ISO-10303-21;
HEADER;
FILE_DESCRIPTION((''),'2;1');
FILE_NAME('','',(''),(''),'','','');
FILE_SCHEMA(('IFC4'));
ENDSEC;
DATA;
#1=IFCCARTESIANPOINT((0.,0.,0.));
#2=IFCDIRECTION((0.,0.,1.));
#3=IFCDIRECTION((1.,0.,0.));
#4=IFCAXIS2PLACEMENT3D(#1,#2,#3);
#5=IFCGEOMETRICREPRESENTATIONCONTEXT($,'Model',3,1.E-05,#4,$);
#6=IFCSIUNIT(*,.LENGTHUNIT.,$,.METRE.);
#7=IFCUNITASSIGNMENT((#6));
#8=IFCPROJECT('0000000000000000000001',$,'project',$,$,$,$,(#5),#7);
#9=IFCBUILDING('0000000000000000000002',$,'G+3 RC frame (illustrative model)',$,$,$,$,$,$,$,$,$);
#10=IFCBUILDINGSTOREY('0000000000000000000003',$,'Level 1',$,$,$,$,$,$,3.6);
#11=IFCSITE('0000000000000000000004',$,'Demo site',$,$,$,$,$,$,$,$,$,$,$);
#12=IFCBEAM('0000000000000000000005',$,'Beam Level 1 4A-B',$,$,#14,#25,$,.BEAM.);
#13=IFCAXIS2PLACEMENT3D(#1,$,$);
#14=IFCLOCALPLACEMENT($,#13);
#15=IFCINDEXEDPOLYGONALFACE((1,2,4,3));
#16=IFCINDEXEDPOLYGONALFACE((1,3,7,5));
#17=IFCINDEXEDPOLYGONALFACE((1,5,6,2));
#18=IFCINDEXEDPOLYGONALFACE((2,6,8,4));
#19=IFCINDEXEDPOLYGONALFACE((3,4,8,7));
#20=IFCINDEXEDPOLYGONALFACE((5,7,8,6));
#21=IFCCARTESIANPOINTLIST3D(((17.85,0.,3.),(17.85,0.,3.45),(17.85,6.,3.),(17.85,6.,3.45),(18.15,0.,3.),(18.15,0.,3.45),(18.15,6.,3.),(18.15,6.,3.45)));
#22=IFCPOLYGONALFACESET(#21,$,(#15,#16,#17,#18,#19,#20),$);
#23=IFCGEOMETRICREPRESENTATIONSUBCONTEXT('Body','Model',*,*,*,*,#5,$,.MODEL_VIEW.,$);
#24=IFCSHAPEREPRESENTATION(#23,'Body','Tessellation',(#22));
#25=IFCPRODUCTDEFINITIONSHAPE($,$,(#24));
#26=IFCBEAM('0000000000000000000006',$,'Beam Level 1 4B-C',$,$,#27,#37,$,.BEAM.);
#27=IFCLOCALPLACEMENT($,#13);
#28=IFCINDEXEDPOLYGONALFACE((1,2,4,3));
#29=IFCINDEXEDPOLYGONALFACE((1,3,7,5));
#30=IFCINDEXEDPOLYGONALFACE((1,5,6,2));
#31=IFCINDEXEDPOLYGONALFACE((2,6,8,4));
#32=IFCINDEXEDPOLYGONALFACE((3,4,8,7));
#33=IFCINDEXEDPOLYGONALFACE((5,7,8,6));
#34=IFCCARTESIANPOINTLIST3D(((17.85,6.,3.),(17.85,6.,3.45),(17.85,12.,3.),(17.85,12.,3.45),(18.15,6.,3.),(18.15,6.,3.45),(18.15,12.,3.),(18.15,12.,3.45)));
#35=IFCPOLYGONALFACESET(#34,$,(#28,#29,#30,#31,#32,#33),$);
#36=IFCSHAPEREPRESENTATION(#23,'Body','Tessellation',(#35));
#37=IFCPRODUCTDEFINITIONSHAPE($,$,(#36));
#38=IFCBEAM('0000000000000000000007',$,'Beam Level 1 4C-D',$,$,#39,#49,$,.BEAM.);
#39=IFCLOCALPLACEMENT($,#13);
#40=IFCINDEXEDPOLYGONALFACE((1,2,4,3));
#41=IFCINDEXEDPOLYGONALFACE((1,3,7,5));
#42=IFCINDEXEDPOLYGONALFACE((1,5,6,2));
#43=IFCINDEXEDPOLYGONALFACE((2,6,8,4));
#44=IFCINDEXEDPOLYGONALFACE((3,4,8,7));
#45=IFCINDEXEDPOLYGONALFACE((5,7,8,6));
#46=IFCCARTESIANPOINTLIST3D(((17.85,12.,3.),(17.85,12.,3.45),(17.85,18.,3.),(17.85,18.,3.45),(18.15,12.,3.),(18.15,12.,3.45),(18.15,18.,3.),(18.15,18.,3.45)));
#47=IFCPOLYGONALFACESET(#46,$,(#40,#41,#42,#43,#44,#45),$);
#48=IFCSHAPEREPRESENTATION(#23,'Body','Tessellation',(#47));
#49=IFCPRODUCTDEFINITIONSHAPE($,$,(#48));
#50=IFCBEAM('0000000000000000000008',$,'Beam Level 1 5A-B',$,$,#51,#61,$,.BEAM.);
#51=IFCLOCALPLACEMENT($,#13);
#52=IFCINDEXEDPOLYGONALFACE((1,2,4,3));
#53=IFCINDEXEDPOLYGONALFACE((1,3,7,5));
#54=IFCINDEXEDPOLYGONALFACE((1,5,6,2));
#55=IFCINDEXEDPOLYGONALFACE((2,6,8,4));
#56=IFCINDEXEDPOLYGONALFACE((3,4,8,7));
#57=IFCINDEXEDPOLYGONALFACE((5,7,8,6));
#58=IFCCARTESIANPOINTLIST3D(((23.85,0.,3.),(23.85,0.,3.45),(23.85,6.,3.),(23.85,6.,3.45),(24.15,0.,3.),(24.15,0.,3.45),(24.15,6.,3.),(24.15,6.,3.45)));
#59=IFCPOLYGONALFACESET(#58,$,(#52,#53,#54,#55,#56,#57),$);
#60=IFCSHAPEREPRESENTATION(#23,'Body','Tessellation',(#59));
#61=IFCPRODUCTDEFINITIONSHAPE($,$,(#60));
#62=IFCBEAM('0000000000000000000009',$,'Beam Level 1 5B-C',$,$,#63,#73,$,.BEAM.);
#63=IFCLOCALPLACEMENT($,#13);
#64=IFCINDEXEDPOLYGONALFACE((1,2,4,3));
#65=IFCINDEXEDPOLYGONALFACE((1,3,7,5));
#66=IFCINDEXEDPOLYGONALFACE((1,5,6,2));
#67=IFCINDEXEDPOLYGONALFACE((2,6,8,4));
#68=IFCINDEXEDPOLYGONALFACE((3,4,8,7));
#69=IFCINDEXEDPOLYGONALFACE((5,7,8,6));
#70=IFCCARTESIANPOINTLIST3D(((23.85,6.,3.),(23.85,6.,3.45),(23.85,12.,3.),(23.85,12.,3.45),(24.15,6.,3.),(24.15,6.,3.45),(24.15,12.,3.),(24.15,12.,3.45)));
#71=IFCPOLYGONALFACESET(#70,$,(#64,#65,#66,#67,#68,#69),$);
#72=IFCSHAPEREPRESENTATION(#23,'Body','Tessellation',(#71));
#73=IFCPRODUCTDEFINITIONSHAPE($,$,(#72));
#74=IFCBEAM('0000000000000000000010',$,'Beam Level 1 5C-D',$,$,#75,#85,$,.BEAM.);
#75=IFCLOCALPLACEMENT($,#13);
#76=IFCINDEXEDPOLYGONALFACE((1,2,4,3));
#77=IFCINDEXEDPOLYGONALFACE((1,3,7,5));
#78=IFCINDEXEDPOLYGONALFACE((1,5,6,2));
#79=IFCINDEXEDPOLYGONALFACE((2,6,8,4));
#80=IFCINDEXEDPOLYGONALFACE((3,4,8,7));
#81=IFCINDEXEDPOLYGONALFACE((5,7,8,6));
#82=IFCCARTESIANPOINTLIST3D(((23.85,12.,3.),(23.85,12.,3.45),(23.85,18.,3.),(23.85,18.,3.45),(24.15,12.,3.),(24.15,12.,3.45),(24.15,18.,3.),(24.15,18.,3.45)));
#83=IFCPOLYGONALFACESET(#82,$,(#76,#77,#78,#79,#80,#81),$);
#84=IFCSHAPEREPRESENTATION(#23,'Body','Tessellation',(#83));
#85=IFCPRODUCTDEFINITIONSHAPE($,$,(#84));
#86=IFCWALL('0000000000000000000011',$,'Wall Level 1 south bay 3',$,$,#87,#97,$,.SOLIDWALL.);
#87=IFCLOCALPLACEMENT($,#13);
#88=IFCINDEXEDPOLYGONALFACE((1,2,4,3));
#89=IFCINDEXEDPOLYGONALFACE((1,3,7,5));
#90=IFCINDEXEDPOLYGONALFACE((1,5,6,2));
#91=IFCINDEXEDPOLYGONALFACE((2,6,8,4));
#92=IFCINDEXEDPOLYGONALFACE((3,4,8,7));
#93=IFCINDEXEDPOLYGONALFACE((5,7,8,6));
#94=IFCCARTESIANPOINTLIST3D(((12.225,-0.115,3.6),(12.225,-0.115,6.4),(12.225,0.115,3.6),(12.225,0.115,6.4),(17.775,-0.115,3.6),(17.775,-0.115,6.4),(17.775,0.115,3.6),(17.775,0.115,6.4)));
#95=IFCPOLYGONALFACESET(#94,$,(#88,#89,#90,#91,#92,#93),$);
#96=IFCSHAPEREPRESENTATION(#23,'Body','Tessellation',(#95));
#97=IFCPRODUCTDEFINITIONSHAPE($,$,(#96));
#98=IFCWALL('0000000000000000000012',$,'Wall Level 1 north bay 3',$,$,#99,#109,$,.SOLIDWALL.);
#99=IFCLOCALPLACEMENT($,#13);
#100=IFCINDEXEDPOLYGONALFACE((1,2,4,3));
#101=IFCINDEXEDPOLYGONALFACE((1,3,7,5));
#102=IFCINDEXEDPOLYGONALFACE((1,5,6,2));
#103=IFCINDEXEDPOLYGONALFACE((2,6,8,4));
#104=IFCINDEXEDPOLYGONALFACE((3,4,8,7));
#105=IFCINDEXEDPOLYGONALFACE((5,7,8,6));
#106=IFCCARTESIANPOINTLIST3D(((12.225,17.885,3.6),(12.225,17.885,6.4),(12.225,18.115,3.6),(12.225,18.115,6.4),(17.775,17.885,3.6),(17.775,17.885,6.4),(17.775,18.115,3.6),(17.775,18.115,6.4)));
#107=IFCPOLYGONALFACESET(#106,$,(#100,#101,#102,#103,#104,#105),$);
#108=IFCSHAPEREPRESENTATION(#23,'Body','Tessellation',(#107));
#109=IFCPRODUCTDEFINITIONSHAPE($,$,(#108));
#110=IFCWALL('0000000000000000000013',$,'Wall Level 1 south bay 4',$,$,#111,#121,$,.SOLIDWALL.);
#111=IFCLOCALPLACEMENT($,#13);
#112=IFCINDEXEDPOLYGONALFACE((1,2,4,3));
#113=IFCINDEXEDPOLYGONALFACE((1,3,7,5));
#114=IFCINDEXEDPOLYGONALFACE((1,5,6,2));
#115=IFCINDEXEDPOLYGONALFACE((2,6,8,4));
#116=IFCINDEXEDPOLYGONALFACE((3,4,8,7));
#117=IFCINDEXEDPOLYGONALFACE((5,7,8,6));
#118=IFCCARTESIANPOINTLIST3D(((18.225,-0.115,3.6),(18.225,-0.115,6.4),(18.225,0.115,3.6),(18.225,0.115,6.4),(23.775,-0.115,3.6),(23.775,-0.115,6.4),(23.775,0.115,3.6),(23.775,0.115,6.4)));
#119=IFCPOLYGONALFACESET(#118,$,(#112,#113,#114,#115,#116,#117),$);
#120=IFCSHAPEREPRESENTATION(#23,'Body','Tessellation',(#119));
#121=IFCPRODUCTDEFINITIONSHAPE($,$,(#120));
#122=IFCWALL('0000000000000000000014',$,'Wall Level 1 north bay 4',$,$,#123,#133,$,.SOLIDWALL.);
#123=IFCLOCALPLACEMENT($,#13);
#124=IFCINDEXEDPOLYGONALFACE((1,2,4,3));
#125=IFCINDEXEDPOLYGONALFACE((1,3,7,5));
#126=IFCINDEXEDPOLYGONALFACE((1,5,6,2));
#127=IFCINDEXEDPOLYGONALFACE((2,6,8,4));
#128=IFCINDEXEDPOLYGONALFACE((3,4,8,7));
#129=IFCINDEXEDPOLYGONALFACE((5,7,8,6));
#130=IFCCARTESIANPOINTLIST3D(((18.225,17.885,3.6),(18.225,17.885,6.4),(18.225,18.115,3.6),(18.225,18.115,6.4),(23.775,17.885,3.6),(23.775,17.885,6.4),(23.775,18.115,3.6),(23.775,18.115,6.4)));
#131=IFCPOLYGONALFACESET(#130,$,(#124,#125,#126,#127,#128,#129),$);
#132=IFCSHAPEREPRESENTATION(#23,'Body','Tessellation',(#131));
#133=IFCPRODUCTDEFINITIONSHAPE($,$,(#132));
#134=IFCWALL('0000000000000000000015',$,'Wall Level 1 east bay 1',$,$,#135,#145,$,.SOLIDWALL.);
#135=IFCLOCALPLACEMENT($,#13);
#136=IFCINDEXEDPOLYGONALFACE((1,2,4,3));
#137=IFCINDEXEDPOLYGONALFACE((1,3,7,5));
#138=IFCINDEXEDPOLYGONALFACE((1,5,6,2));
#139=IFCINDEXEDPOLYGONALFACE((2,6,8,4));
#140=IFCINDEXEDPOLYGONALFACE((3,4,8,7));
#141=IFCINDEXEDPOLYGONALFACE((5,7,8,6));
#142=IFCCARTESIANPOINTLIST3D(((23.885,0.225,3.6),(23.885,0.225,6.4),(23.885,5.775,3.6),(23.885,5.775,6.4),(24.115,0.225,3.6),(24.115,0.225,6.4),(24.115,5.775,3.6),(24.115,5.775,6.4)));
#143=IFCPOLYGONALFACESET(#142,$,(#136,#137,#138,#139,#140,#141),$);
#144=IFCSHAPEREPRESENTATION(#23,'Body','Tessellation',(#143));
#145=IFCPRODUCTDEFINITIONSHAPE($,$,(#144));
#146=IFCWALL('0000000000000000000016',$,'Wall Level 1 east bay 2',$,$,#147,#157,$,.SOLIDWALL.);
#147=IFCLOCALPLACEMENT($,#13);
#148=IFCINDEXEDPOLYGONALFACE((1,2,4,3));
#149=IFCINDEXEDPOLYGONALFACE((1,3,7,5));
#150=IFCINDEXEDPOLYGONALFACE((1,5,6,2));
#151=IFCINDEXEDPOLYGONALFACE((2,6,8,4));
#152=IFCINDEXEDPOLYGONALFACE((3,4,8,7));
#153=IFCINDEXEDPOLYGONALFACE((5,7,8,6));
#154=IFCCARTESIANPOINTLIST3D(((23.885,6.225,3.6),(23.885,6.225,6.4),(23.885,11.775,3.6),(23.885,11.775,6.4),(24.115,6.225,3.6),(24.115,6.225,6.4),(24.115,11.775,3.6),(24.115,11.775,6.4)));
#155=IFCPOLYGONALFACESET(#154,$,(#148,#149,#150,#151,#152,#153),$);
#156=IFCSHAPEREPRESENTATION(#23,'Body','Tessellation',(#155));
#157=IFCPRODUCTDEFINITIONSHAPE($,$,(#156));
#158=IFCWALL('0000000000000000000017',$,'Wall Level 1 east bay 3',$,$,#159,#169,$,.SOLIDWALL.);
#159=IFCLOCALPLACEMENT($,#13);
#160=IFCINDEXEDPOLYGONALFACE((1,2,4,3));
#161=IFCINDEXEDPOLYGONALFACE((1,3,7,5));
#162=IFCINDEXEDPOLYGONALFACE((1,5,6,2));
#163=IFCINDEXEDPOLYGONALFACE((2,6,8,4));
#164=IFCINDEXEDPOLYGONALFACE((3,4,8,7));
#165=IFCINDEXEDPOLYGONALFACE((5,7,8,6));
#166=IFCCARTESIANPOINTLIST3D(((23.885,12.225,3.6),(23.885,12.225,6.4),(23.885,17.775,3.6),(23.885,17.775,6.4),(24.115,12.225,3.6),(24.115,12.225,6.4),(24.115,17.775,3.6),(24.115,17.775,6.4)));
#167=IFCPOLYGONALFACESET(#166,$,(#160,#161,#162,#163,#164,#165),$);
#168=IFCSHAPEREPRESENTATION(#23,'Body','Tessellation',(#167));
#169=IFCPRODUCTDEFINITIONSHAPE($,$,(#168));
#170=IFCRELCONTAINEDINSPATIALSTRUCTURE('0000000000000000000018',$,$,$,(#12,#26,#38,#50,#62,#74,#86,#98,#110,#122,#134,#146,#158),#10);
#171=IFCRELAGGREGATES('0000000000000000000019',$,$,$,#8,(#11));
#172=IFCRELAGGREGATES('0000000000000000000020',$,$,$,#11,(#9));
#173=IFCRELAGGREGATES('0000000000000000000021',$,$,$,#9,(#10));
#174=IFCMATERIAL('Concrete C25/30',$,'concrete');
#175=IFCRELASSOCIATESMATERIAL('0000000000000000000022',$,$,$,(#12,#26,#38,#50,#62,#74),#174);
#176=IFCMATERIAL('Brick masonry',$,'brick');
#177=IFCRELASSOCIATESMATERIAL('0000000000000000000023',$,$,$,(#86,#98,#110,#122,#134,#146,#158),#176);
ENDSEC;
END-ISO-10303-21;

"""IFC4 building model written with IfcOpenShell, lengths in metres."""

from ifc_helpers import new_model, si_unit, frame, frame_2d, origin, origin_with_axes, place, context, subcontext, project, spatial, rectangle, extrude, material, element, save


model = new_model("IFC4")

# Units and contexts
model_context = context("Model", 3, precision=1e-05, world=origin_with_axes())
body_context = subcontext(model_context, "Body", "Model", "MODEL_VIEW")
ifc_project = project(units=[si_unit("LENGTHUNIT", "METRE")], contexts=[model_context])

# Site, building, storey
site = spatial("IfcSite", under=ifc_project, Name="Demo site")
building = spatial("IfcBuilding", under=site, Name="G+3 RC frame (illustrative model)")
storey = spatial("IfcBuildingStorey", under=building, Name="Level 1", Elevation=3.6)

# Shared definitions
ifc_material_1 = material(Name="Concrete C25/30", Category="concrete")

# Beams
for number, where, z_axis, x_axis, name in (
    (1, (17.85, 0.0, 3.0), (0.0, 0.0, 1.0), (1.0, 0.0, 0.0), "Beam Level 1 4A-B"),
    (2, (17.85, 6.0, 3.0), (0.0, 0.0, 1.0), (1.0, 0.0, 0.0), "Beam Level 1 4B-C"),
    (3, (17.85, 12.0, 3.0), (0.0, 0.0, 1.0), (1.0, 0.0, 0.0), "Beam Level 1 4C-D"),
    (4, (23.85, 0.0, 3.0), (0.0, 0.0, 1.0), (1.0, 0.0, 0.0), "Beam Level 1 5A-B"),
    (5, (23.85, 6.0, 3.0), (0.0, 0.0, 1.0), (1.0, 0.0, 0.0), "Beam Level 1 5B-C"),
    (6, (23.85, 12.0, 3.0), (0.0, 0.0, 1.0), (1.0, 0.0, 0.0), "Beam Level 1 5C-D"),
):
    element("IfcBeam", number, at=place(None, frame(where, z_axis=z_axis, x_axis=x_axis)), inside=storey, material=ifc_material_1, Name=name, PredefinedType="BEAM", context=body_context, shape_type="SweptSolid", body=[
        extrude(rectangle(XDim=0.3, YDim=6.0, at=frame_2d((0.15, 3.0))), origin(), (0.0, 0.0, 1.0), 0.45),
    ])

# Walls
ifc_material_2 = material(Name="Brick masonry", Category="brick")
for number, where, z_axis, x_axis, name in (
    (7, (12.225, -0.115, 3.6), (0.0, 0.0, 1.0), (1.0, 0.0, 0.0), "Wall Level 1 south bay 3"),
    (8, (12.225, 17.885, 3.6), (0.0, 0.0, 1.0), (1.0, 0.0, 0.0), "Wall Level 1 north bay 3"),
    (9, (18.225, -0.115, 3.6), (0.0, 0.0, 1.0), (1.0, 0.0, 0.0), "Wall Level 1 south bay 4"),
    (10, (18.225, 17.885, 3.6), (0.0, 0.0, 1.0), (1.0, 0.0, 0.0), "Wall Level 1 north bay 4"),
):
    element("IfcWall", number, at=place(None, frame(where, z_axis=z_axis, x_axis=x_axis)), inside=storey, material=ifc_material_2, Name=name, PredefinedType="SOLIDWALL", context=body_context, shape_type="SweptSolid", body=[
        extrude(rectangle(XDim=5.55, YDim=0.23, at=frame_2d((2.775, 0.115))), origin(), (0.0, 0.0, 1.0), 2.8),
    ])
for number, where, z_axis, x_axis, name in (
    (11, (23.885, 0.225, 3.6), (0.0, 0.0, 1.0), (1.0, 0.0, 0.0), "Wall Level 1 east bay 1"),
    (12, (23.885, 6.225, 3.6), (0.0, 0.0, 1.0), (1.0, 0.0, 0.0), "Wall Level 1 east bay 2"),
    (13, (23.885, 12.225, 3.6), (0.0, 0.0, 1.0), (1.0, 0.0, 0.0), "Wall Level 1 east bay 3"),
):
    element("IfcWall", number, at=place(None, frame(where, z_axis=z_axis, x_axis=x_axis)), inside=storey, material=ifc_material_2, Name=name, PredefinedType="SOLIDWALL", context=body_context, shape_type="SweptSolid", body=[
        extrude(rectangle(XDim=0.23, YDim=5.55, at=frame_2d((0.115, 2.775))), origin(), (0.0, 0.0, 1.0), 2.8),
    ])

save(model, "model.ifc")
